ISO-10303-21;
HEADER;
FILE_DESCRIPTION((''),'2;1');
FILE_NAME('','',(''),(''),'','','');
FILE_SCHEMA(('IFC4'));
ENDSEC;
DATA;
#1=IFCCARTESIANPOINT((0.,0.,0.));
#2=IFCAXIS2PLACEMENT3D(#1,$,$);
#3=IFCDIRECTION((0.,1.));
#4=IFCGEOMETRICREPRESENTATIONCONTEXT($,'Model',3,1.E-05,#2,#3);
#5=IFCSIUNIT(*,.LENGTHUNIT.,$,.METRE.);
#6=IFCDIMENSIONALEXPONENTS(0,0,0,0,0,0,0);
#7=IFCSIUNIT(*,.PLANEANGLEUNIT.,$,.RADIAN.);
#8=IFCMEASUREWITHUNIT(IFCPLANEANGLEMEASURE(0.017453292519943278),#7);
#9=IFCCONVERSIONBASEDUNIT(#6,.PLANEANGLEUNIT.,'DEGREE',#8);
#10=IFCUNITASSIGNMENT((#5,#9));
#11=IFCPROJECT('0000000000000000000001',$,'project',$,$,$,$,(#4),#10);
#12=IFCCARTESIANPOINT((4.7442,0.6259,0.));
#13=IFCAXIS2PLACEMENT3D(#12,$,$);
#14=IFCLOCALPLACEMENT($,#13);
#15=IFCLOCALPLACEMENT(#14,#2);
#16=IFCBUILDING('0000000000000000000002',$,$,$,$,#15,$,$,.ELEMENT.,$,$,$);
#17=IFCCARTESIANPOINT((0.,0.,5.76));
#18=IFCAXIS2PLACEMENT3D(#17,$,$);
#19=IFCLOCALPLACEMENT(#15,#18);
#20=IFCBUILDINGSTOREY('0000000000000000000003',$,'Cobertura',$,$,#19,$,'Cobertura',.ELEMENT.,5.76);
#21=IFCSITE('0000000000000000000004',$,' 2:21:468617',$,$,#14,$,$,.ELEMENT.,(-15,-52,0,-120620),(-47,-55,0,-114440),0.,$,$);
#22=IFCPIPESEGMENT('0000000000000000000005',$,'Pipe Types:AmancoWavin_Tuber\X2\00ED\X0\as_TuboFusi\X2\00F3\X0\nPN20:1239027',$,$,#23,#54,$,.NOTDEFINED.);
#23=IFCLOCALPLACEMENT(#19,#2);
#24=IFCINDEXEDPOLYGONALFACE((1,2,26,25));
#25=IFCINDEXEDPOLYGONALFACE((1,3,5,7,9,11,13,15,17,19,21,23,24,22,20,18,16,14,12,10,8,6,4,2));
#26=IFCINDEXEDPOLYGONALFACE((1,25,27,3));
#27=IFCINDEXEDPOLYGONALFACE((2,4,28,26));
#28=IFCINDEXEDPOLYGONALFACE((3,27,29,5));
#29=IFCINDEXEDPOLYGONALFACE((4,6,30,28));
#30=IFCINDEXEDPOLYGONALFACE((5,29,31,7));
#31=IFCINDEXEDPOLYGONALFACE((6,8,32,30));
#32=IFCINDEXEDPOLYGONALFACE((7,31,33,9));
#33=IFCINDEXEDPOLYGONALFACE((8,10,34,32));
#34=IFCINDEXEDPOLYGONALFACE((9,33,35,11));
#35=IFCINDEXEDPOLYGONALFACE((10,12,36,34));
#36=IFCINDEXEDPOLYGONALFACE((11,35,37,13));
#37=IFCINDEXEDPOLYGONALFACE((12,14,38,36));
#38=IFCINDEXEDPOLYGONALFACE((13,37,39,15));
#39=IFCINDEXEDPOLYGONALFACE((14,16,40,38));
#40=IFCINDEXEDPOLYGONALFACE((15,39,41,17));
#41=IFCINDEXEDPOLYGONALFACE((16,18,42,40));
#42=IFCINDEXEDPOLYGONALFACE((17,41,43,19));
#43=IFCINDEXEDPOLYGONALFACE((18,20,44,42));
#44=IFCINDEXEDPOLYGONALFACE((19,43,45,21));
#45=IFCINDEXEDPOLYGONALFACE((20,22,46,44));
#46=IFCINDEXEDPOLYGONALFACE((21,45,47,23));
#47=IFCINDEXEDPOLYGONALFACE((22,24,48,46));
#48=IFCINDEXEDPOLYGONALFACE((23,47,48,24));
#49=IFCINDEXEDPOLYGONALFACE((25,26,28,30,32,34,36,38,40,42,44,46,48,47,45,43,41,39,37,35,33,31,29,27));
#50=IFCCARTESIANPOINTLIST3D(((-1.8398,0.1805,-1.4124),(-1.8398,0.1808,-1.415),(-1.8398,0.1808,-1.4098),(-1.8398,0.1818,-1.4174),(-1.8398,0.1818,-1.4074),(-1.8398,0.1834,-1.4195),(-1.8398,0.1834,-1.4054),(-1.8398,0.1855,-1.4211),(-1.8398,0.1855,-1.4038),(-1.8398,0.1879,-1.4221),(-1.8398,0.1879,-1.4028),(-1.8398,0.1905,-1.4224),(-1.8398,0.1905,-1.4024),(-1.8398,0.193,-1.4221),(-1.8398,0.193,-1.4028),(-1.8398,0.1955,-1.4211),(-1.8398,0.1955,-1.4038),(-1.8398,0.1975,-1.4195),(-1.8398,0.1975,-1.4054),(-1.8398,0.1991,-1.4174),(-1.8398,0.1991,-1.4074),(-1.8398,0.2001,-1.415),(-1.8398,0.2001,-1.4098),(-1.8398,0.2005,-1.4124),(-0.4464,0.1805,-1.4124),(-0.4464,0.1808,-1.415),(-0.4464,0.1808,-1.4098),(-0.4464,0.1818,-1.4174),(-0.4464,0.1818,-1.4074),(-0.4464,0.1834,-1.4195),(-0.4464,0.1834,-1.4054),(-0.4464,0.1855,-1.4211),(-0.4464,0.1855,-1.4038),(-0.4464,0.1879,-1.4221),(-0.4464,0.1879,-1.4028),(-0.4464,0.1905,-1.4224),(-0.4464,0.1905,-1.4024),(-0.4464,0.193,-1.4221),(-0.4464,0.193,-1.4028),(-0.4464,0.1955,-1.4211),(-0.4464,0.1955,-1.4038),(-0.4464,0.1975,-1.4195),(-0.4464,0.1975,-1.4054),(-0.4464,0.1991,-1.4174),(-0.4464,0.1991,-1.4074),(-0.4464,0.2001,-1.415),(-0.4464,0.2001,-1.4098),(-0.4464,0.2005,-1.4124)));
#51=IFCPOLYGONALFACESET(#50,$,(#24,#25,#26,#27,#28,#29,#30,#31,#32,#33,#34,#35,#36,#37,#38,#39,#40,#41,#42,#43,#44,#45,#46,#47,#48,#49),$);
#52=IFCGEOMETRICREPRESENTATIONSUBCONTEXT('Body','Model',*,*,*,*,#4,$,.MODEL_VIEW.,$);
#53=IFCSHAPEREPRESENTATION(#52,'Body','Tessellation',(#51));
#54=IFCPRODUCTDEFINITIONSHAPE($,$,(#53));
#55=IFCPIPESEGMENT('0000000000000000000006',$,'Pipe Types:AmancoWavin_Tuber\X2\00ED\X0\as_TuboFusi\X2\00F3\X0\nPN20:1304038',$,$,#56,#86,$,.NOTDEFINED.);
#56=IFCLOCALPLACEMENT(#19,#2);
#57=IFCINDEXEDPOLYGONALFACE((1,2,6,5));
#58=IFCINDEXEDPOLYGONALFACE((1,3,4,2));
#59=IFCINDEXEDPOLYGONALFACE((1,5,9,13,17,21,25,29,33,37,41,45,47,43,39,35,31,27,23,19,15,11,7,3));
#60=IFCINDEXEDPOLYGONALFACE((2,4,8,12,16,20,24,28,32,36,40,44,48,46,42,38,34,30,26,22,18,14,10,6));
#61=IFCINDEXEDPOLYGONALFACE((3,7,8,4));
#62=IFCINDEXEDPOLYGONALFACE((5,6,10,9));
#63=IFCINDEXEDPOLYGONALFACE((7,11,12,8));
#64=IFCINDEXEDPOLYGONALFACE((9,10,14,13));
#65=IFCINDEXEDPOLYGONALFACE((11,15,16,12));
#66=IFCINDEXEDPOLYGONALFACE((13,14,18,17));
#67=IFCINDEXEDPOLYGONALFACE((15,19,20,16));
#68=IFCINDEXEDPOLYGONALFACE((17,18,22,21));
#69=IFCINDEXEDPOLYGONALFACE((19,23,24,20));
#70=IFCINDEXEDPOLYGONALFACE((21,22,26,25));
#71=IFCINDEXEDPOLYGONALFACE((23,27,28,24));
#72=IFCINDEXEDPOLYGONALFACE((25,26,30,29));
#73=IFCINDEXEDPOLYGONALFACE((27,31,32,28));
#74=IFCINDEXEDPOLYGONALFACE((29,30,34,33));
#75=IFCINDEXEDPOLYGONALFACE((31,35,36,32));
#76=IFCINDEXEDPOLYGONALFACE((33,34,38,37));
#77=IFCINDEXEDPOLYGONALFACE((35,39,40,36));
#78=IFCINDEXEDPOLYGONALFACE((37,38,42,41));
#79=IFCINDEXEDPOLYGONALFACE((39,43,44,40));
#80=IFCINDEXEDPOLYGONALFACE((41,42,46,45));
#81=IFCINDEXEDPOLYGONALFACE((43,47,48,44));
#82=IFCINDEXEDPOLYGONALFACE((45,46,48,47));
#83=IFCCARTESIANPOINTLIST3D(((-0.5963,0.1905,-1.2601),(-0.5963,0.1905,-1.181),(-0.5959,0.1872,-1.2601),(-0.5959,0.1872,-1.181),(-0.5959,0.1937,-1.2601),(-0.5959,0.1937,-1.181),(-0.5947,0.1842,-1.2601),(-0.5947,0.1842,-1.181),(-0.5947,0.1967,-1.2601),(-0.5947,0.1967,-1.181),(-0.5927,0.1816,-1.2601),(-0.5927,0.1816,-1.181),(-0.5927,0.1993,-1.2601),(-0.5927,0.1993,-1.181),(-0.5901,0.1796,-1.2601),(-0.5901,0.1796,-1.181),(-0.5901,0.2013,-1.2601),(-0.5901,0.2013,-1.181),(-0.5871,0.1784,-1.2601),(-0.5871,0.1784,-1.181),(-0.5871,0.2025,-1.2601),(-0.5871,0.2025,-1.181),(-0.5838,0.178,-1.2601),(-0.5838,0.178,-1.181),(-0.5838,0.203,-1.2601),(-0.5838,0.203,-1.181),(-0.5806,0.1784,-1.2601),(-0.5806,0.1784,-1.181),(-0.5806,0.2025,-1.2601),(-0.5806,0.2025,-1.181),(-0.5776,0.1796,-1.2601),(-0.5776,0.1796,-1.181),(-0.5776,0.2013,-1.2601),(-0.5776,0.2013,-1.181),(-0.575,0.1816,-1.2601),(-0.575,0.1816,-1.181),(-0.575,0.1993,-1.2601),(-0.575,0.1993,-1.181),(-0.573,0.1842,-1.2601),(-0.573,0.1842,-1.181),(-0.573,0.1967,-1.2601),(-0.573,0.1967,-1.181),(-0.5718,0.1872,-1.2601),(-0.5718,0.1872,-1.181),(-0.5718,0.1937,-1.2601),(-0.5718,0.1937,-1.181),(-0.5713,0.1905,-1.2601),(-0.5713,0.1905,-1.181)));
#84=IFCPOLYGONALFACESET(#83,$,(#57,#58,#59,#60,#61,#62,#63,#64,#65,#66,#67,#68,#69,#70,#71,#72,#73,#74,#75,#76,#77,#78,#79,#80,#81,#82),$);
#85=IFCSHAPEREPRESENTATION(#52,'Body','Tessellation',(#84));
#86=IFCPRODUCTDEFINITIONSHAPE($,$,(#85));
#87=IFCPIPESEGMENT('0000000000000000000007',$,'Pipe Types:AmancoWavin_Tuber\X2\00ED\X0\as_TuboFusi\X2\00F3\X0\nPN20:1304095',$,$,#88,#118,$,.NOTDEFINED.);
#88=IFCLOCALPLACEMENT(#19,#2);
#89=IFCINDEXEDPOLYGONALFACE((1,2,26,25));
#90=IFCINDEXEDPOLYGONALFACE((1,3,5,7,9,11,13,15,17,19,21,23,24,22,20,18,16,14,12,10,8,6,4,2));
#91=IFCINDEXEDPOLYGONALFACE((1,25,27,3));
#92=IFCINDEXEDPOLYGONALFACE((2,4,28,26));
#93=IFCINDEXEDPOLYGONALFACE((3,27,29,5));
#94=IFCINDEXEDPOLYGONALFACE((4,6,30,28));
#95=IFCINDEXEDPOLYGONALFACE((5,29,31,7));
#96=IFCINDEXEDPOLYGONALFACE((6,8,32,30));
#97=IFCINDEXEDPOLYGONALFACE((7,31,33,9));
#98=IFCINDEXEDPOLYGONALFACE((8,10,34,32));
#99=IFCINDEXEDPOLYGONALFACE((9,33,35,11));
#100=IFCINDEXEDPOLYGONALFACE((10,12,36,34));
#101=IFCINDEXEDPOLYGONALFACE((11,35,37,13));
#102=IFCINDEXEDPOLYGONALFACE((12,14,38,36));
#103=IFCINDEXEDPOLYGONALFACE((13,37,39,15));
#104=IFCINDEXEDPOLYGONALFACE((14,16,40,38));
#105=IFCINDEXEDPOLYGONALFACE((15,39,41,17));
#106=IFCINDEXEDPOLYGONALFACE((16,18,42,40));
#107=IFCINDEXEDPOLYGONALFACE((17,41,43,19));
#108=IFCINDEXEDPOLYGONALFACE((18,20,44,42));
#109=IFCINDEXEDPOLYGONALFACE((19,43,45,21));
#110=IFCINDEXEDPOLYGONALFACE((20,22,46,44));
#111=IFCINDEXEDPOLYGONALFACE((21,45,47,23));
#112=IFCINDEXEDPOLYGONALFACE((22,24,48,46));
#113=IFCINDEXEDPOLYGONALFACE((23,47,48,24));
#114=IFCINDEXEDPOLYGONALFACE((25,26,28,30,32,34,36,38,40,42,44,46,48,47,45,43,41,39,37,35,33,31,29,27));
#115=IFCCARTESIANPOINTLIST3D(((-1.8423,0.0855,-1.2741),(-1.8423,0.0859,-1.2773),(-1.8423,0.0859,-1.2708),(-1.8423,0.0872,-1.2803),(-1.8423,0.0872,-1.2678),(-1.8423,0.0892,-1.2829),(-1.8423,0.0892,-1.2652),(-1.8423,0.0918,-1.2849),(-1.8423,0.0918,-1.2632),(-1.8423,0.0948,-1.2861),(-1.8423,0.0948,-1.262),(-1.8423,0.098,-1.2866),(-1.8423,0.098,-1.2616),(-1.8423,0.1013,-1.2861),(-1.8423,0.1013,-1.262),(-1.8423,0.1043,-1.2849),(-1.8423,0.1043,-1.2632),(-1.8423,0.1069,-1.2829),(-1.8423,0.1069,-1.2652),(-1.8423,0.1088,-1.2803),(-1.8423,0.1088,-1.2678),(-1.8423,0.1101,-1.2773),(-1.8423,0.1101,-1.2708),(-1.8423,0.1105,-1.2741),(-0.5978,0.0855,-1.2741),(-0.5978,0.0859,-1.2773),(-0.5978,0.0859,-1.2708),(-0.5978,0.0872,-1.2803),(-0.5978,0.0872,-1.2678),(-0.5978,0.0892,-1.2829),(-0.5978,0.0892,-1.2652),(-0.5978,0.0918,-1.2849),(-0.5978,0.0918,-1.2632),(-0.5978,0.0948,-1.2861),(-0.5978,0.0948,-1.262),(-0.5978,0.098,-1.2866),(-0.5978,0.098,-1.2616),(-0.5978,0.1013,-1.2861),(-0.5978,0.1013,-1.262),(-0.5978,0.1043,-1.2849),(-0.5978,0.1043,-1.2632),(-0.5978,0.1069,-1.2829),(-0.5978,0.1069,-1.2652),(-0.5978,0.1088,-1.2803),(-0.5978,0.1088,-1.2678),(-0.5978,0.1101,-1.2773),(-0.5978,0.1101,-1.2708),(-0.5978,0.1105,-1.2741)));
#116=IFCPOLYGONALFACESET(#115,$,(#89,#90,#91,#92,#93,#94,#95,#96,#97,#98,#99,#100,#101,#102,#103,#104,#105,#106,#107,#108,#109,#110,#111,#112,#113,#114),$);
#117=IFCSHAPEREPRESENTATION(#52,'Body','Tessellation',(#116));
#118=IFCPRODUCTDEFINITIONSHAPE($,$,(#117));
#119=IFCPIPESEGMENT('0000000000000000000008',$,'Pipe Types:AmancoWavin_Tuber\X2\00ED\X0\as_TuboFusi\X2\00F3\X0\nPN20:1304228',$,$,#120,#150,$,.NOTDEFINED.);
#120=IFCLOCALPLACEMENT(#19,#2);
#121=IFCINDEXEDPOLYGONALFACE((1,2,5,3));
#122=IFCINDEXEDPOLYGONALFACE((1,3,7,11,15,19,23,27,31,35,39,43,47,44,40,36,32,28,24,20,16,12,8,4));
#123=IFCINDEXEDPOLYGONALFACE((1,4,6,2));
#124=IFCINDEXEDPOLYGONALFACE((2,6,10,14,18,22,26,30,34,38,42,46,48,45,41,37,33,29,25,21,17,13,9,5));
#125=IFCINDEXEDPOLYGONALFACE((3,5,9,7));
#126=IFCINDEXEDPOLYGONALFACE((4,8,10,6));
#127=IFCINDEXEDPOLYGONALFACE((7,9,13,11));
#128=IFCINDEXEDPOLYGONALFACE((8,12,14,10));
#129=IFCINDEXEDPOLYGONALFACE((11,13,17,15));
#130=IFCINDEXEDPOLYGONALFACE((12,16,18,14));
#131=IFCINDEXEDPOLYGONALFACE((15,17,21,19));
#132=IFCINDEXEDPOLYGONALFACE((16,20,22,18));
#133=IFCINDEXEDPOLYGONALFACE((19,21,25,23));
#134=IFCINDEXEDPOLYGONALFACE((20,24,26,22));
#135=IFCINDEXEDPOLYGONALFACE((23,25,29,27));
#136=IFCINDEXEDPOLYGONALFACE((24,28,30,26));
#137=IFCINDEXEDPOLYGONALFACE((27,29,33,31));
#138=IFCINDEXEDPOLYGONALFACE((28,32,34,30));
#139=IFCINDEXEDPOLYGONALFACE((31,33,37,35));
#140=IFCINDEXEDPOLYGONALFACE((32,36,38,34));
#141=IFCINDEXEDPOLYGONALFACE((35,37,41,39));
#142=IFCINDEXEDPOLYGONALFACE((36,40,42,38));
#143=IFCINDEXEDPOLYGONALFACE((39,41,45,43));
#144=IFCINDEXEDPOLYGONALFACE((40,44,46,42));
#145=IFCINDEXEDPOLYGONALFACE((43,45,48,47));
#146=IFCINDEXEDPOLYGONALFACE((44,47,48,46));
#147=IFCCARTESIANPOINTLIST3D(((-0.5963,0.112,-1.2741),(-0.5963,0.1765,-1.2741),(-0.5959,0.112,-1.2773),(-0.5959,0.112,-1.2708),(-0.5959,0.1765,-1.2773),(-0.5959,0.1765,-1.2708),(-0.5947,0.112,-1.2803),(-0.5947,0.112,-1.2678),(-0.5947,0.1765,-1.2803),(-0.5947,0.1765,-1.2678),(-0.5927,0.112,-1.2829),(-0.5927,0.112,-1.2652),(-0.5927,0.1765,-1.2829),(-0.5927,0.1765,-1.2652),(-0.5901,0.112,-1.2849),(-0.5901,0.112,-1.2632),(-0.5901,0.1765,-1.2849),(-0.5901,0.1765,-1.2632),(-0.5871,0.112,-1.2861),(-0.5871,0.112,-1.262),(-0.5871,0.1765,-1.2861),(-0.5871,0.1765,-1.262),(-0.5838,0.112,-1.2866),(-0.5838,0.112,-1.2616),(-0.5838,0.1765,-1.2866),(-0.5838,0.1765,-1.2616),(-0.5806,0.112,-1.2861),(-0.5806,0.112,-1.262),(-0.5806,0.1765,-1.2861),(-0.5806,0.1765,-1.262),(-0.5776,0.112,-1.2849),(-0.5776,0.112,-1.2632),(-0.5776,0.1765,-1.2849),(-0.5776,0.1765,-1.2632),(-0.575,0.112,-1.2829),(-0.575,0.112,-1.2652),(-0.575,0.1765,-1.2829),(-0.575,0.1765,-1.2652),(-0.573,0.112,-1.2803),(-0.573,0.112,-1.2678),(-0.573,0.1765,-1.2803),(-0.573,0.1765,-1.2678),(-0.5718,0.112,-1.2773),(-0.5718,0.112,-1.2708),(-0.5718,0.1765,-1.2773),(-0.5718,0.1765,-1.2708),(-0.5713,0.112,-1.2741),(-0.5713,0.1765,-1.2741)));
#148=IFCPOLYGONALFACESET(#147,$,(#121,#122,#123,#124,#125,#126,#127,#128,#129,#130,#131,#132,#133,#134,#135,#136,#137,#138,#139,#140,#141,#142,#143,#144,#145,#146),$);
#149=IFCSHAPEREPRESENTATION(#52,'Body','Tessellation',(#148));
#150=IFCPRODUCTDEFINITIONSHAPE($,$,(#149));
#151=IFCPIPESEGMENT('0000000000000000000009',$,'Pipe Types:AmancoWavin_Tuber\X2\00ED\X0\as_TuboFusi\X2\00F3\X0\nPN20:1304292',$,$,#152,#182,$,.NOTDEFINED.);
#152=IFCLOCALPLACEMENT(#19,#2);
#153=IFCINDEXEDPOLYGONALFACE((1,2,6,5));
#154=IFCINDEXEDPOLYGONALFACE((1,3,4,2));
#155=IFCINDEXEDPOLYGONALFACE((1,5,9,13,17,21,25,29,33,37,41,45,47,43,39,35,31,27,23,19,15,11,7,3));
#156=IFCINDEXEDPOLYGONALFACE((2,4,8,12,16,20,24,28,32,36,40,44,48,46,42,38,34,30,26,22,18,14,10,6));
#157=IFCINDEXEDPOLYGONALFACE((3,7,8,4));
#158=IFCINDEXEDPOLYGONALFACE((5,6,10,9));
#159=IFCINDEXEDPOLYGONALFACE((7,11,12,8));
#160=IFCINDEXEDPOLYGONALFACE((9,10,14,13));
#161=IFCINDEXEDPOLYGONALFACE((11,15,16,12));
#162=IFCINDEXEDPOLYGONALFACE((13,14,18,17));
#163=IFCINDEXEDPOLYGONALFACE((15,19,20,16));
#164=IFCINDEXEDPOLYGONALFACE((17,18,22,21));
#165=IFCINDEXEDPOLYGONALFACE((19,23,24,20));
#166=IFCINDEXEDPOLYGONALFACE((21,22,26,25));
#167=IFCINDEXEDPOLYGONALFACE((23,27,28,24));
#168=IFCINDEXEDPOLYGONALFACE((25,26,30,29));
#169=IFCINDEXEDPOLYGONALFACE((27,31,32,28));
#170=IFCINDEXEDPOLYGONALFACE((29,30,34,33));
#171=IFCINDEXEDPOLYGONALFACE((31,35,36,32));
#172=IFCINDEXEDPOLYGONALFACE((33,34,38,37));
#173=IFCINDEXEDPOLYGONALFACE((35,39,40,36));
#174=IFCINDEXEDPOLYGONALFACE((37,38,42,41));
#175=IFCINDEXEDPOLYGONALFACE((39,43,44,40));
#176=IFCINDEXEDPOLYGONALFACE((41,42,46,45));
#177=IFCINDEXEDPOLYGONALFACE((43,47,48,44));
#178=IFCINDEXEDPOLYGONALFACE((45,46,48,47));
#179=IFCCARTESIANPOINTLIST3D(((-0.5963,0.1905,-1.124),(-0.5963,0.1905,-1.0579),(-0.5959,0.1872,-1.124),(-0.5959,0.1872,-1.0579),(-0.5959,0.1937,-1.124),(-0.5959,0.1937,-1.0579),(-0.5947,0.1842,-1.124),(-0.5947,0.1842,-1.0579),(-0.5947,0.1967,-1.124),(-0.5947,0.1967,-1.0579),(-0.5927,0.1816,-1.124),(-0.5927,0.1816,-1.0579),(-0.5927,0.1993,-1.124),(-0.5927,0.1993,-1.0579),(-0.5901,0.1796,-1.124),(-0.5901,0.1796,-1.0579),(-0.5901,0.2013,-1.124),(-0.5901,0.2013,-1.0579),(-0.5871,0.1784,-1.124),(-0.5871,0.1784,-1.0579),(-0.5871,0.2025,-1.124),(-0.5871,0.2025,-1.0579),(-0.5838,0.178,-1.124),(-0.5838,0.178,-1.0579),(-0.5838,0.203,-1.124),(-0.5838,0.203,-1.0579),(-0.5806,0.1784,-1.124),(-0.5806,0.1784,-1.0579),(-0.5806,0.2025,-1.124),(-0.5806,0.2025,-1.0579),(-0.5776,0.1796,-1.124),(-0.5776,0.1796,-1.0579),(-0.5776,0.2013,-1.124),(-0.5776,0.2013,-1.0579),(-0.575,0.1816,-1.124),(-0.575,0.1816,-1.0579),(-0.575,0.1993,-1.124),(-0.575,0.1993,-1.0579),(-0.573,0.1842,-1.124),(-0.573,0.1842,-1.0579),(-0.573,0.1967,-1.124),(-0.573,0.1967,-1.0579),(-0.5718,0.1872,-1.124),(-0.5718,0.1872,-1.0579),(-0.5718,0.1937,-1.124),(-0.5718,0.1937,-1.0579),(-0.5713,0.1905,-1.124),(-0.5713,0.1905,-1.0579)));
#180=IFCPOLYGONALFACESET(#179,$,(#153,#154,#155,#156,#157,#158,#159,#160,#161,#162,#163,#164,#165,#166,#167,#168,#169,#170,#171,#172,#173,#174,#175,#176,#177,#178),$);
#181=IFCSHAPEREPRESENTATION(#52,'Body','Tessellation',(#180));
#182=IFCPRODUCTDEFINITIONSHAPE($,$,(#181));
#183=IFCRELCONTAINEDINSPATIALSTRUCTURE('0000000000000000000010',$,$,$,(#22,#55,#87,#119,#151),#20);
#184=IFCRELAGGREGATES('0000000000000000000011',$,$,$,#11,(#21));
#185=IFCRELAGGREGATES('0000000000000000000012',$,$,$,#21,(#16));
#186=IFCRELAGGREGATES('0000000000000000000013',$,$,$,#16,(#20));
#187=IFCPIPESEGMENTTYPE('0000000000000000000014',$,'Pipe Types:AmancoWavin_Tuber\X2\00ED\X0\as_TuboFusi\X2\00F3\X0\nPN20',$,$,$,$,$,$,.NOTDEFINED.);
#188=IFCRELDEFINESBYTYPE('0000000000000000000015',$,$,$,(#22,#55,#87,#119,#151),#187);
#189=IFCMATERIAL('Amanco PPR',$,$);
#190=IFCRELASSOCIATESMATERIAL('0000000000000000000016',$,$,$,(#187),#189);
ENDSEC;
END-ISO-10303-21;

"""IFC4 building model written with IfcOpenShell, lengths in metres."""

from ifc_helpers import new_model, entity, si_unit, converted_unit, direction, frame, origin, place, context, subcontext, project, spatial, arc, indexed_curve, outline, extrude, material, type_object, element, save


model = new_model("IFC4")

# Units and contexts
model_context = context("Model", 3, precision=1e-05, world=origin(), true_north=direction((0.0, 1.0)))
body_context = subcontext(model_context, "Body", "Model", "MODEL_VIEW")
ifc_project = project(units=[si_unit("LENGTHUNIT", "METRE"), converted_unit("PLANEANGLEUNIT", "DEGREE", entity("IfcPlaneAngleMeasure", 0.017453292519943278), si_unit("PLANEANGLEUNIT", "RADIAN"), dimensions=[0, 0, 0, 0, 0, 0, 0])], contexts=[model_context])

# Site, building, storey
site_placement = place(None, frame((4.7442, 0.6259, 0.0)))
site = spatial("IfcSite", under=ifc_project, at=site_placement, Name=" 2:21:468617", CompositionType="ELEMENT", RefLatitude=(-15, -52, 0, -120620), RefLongitude=(-47, -55, 0, -114440), RefElevation=0.0)
building_placement = place(site_placement, origin())
building = spatial("IfcBuilding", under=site, at=building_placement, CompositionType="ELEMENT")
storey_placement = place(building_placement, frame((0.0, 0.0, 5.76)))
storey = spatial("IfcBuildingStorey", under=building, at=storey_placement, Name="Cobertura", LongName="Cobertura", CompositionType="ELEMENT", Elevation=5.76)

# Pipe segments
ifc_material = material(Name="Amanco PPR")
pipe_segment_type = type_object("IfcPipeSegmentType", Name="Pipe Types:AmancoWavin_Tuberías_TuboFusiónPN20", PredefinedType="NOTDEFINED", material=ifc_material)
pipe_segment_1_placement = place(storey_placement, origin())
element("IfcPipeSegment", 1, at=pipe_segment_1_placement, inside=storey, type_object=pipe_segment_type, Name="Pipe Types:AmancoWavin_Tuberías_TuboFusiónPN20:1239027", PredefinedType="NOTDEFINED", context=body_context, shape_type="SweptSolid", body=[
    extrude(outline(indexed_curve([(0.01, 0.0), (0.0071, 0.0071), (0.0, 0.01), (-0.0071, 0.0071), (-0.01, 0.0), (-0.0071, -0.0071), (0.0, -0.01), (0.0071, -0.0071)], segments=[arc(1, 2, 3), arc(3, 4, 5), arc(5, 6, 7), arc(7, 8, 1)], self_intersect=False)), frame((-1.8398, 0.1905, -1.4124), z_axis=(1.0, 0.0, 0.0), x_axis=(0.0, 1.0, 0.0)), (0.0, 0.0, 1.0), 1.3934),
])
pipe_segment_2_placement = place(storey_placement, origin())
element("IfcPipeSegment", 2, at=pipe_segment_2_placement, inside=storey, type_object=pipe_segment_type, Name="Pipe Types:AmancoWavin_Tuberías_TuboFusiónPN20:1304038", PredefinedType="NOTDEFINED", context=body_context, shape_type="SweptSolid", body=[
    extrude(outline(indexed_curve([(0.0125, 0.0), (0.0088, 0.0088), (0.0, 0.0125), (-0.0088, 0.0088), (-0.0125, 0.0), (-0.0088, -0.0088), (0.0, -0.0125), (0.0088, -0.0088)], segments=[arc(1, 2, 3), arc(3, 4, 5), arc(5, 6, 7), arc(7, 8, 1)], self_intersect=False)), frame((-0.5838, 0.1905, -1.2601)), (0.0, 0.0, 1.0), 0.0791),
])
pipe_segment_3_placement = place(storey_placement, origin())
element("IfcPipeSegment", 3, at=pipe_segment_3_placement, inside=storey, type_object=pipe_segment_type, Name="Pipe Types:AmancoWavin_Tuberías_TuboFusiónPN20:1304095", PredefinedType="NOTDEFINED", context=body_context, shape_type="SweptSolid", body=[
    extrude(outline(indexed_curve([(0.0125, 0.0), (0.0088, 0.0088), (0.0, 0.0125), (-0.0088, 0.0088), (-0.0125, 0.0), (-0.0088, -0.0088), (0.0, -0.0125), (0.0088, -0.0088)], segments=[arc(1, 2, 3), arc(3, 4, 5), arc(5, 6, 7), arc(7, 8, 1)], self_intersect=False)), frame((-1.8423, 0.098, -1.2741), z_axis=(1.0, 0.0, 0.0), x_axis=(0.0, 1.0, 0.0)), (0.0, 0.0, 1.0), 1.2444),
])
pipe_segment_4_placement = place(storey_placement, origin())
element("IfcPipeSegment", 4, at=pipe_segment_4_placement, inside=storey, type_object=pipe_segment_type, Name="Pipe Types:AmancoWavin_Tuberías_TuboFusiónPN20:1304228", PredefinedType="NOTDEFINED", context=body_context, shape_type="SweptSolid", body=[
    extrude(outline(indexed_curve([(0.0125, 0.0), (0.0088, 0.0088), (0.0, 0.0125), (-0.0088, 0.0088), (-0.0125, 0.0), (-0.0088, -0.0088), (0.0, -0.0125), (0.0088, -0.0088)], segments=[arc(1, 2, 3), arc(3, 4, 5), arc(5, 6, 7), arc(7, 8, 1)], self_intersect=False)), frame((-0.5838, 0.112, -1.2741), z_axis=(0.0, 1.0, 0.0), x_axis=(-1.0, 0.0, 0.0)), (0.0, 0.0, 1.0), 0.0644),
])
pipe_segment_5_placement = place(storey_placement, origin())
element("IfcPipeSegment", 5, at=pipe_segment_5_placement, inside=storey, type_object=pipe_segment_type, Name="Pipe Types:AmancoWavin_Tuberías_TuboFusiónPN20:1304292", PredefinedType="NOTDEFINED", context=body_context, shape_type="SweptSolid", body=[
    extrude(outline(indexed_curve([(0.0125, 0.0), (0.0088, 0.0088), (0.0, 0.0125), (-0.0088, 0.0088), (-0.0125, 0.0), (-0.0088, -0.0088), (0.0, -0.0125), (0.0088, -0.0088)], segments=[arc(1, 2, 3), arc(3, 4, 5), arc(5, 6, 7), arc(7, 8, 1)], self_intersect=False)), frame((-0.5838, 0.1905, -1.124)), (0.0, 0.0, 1.0), 0.0661),
])

save(model, "model.ifc")
